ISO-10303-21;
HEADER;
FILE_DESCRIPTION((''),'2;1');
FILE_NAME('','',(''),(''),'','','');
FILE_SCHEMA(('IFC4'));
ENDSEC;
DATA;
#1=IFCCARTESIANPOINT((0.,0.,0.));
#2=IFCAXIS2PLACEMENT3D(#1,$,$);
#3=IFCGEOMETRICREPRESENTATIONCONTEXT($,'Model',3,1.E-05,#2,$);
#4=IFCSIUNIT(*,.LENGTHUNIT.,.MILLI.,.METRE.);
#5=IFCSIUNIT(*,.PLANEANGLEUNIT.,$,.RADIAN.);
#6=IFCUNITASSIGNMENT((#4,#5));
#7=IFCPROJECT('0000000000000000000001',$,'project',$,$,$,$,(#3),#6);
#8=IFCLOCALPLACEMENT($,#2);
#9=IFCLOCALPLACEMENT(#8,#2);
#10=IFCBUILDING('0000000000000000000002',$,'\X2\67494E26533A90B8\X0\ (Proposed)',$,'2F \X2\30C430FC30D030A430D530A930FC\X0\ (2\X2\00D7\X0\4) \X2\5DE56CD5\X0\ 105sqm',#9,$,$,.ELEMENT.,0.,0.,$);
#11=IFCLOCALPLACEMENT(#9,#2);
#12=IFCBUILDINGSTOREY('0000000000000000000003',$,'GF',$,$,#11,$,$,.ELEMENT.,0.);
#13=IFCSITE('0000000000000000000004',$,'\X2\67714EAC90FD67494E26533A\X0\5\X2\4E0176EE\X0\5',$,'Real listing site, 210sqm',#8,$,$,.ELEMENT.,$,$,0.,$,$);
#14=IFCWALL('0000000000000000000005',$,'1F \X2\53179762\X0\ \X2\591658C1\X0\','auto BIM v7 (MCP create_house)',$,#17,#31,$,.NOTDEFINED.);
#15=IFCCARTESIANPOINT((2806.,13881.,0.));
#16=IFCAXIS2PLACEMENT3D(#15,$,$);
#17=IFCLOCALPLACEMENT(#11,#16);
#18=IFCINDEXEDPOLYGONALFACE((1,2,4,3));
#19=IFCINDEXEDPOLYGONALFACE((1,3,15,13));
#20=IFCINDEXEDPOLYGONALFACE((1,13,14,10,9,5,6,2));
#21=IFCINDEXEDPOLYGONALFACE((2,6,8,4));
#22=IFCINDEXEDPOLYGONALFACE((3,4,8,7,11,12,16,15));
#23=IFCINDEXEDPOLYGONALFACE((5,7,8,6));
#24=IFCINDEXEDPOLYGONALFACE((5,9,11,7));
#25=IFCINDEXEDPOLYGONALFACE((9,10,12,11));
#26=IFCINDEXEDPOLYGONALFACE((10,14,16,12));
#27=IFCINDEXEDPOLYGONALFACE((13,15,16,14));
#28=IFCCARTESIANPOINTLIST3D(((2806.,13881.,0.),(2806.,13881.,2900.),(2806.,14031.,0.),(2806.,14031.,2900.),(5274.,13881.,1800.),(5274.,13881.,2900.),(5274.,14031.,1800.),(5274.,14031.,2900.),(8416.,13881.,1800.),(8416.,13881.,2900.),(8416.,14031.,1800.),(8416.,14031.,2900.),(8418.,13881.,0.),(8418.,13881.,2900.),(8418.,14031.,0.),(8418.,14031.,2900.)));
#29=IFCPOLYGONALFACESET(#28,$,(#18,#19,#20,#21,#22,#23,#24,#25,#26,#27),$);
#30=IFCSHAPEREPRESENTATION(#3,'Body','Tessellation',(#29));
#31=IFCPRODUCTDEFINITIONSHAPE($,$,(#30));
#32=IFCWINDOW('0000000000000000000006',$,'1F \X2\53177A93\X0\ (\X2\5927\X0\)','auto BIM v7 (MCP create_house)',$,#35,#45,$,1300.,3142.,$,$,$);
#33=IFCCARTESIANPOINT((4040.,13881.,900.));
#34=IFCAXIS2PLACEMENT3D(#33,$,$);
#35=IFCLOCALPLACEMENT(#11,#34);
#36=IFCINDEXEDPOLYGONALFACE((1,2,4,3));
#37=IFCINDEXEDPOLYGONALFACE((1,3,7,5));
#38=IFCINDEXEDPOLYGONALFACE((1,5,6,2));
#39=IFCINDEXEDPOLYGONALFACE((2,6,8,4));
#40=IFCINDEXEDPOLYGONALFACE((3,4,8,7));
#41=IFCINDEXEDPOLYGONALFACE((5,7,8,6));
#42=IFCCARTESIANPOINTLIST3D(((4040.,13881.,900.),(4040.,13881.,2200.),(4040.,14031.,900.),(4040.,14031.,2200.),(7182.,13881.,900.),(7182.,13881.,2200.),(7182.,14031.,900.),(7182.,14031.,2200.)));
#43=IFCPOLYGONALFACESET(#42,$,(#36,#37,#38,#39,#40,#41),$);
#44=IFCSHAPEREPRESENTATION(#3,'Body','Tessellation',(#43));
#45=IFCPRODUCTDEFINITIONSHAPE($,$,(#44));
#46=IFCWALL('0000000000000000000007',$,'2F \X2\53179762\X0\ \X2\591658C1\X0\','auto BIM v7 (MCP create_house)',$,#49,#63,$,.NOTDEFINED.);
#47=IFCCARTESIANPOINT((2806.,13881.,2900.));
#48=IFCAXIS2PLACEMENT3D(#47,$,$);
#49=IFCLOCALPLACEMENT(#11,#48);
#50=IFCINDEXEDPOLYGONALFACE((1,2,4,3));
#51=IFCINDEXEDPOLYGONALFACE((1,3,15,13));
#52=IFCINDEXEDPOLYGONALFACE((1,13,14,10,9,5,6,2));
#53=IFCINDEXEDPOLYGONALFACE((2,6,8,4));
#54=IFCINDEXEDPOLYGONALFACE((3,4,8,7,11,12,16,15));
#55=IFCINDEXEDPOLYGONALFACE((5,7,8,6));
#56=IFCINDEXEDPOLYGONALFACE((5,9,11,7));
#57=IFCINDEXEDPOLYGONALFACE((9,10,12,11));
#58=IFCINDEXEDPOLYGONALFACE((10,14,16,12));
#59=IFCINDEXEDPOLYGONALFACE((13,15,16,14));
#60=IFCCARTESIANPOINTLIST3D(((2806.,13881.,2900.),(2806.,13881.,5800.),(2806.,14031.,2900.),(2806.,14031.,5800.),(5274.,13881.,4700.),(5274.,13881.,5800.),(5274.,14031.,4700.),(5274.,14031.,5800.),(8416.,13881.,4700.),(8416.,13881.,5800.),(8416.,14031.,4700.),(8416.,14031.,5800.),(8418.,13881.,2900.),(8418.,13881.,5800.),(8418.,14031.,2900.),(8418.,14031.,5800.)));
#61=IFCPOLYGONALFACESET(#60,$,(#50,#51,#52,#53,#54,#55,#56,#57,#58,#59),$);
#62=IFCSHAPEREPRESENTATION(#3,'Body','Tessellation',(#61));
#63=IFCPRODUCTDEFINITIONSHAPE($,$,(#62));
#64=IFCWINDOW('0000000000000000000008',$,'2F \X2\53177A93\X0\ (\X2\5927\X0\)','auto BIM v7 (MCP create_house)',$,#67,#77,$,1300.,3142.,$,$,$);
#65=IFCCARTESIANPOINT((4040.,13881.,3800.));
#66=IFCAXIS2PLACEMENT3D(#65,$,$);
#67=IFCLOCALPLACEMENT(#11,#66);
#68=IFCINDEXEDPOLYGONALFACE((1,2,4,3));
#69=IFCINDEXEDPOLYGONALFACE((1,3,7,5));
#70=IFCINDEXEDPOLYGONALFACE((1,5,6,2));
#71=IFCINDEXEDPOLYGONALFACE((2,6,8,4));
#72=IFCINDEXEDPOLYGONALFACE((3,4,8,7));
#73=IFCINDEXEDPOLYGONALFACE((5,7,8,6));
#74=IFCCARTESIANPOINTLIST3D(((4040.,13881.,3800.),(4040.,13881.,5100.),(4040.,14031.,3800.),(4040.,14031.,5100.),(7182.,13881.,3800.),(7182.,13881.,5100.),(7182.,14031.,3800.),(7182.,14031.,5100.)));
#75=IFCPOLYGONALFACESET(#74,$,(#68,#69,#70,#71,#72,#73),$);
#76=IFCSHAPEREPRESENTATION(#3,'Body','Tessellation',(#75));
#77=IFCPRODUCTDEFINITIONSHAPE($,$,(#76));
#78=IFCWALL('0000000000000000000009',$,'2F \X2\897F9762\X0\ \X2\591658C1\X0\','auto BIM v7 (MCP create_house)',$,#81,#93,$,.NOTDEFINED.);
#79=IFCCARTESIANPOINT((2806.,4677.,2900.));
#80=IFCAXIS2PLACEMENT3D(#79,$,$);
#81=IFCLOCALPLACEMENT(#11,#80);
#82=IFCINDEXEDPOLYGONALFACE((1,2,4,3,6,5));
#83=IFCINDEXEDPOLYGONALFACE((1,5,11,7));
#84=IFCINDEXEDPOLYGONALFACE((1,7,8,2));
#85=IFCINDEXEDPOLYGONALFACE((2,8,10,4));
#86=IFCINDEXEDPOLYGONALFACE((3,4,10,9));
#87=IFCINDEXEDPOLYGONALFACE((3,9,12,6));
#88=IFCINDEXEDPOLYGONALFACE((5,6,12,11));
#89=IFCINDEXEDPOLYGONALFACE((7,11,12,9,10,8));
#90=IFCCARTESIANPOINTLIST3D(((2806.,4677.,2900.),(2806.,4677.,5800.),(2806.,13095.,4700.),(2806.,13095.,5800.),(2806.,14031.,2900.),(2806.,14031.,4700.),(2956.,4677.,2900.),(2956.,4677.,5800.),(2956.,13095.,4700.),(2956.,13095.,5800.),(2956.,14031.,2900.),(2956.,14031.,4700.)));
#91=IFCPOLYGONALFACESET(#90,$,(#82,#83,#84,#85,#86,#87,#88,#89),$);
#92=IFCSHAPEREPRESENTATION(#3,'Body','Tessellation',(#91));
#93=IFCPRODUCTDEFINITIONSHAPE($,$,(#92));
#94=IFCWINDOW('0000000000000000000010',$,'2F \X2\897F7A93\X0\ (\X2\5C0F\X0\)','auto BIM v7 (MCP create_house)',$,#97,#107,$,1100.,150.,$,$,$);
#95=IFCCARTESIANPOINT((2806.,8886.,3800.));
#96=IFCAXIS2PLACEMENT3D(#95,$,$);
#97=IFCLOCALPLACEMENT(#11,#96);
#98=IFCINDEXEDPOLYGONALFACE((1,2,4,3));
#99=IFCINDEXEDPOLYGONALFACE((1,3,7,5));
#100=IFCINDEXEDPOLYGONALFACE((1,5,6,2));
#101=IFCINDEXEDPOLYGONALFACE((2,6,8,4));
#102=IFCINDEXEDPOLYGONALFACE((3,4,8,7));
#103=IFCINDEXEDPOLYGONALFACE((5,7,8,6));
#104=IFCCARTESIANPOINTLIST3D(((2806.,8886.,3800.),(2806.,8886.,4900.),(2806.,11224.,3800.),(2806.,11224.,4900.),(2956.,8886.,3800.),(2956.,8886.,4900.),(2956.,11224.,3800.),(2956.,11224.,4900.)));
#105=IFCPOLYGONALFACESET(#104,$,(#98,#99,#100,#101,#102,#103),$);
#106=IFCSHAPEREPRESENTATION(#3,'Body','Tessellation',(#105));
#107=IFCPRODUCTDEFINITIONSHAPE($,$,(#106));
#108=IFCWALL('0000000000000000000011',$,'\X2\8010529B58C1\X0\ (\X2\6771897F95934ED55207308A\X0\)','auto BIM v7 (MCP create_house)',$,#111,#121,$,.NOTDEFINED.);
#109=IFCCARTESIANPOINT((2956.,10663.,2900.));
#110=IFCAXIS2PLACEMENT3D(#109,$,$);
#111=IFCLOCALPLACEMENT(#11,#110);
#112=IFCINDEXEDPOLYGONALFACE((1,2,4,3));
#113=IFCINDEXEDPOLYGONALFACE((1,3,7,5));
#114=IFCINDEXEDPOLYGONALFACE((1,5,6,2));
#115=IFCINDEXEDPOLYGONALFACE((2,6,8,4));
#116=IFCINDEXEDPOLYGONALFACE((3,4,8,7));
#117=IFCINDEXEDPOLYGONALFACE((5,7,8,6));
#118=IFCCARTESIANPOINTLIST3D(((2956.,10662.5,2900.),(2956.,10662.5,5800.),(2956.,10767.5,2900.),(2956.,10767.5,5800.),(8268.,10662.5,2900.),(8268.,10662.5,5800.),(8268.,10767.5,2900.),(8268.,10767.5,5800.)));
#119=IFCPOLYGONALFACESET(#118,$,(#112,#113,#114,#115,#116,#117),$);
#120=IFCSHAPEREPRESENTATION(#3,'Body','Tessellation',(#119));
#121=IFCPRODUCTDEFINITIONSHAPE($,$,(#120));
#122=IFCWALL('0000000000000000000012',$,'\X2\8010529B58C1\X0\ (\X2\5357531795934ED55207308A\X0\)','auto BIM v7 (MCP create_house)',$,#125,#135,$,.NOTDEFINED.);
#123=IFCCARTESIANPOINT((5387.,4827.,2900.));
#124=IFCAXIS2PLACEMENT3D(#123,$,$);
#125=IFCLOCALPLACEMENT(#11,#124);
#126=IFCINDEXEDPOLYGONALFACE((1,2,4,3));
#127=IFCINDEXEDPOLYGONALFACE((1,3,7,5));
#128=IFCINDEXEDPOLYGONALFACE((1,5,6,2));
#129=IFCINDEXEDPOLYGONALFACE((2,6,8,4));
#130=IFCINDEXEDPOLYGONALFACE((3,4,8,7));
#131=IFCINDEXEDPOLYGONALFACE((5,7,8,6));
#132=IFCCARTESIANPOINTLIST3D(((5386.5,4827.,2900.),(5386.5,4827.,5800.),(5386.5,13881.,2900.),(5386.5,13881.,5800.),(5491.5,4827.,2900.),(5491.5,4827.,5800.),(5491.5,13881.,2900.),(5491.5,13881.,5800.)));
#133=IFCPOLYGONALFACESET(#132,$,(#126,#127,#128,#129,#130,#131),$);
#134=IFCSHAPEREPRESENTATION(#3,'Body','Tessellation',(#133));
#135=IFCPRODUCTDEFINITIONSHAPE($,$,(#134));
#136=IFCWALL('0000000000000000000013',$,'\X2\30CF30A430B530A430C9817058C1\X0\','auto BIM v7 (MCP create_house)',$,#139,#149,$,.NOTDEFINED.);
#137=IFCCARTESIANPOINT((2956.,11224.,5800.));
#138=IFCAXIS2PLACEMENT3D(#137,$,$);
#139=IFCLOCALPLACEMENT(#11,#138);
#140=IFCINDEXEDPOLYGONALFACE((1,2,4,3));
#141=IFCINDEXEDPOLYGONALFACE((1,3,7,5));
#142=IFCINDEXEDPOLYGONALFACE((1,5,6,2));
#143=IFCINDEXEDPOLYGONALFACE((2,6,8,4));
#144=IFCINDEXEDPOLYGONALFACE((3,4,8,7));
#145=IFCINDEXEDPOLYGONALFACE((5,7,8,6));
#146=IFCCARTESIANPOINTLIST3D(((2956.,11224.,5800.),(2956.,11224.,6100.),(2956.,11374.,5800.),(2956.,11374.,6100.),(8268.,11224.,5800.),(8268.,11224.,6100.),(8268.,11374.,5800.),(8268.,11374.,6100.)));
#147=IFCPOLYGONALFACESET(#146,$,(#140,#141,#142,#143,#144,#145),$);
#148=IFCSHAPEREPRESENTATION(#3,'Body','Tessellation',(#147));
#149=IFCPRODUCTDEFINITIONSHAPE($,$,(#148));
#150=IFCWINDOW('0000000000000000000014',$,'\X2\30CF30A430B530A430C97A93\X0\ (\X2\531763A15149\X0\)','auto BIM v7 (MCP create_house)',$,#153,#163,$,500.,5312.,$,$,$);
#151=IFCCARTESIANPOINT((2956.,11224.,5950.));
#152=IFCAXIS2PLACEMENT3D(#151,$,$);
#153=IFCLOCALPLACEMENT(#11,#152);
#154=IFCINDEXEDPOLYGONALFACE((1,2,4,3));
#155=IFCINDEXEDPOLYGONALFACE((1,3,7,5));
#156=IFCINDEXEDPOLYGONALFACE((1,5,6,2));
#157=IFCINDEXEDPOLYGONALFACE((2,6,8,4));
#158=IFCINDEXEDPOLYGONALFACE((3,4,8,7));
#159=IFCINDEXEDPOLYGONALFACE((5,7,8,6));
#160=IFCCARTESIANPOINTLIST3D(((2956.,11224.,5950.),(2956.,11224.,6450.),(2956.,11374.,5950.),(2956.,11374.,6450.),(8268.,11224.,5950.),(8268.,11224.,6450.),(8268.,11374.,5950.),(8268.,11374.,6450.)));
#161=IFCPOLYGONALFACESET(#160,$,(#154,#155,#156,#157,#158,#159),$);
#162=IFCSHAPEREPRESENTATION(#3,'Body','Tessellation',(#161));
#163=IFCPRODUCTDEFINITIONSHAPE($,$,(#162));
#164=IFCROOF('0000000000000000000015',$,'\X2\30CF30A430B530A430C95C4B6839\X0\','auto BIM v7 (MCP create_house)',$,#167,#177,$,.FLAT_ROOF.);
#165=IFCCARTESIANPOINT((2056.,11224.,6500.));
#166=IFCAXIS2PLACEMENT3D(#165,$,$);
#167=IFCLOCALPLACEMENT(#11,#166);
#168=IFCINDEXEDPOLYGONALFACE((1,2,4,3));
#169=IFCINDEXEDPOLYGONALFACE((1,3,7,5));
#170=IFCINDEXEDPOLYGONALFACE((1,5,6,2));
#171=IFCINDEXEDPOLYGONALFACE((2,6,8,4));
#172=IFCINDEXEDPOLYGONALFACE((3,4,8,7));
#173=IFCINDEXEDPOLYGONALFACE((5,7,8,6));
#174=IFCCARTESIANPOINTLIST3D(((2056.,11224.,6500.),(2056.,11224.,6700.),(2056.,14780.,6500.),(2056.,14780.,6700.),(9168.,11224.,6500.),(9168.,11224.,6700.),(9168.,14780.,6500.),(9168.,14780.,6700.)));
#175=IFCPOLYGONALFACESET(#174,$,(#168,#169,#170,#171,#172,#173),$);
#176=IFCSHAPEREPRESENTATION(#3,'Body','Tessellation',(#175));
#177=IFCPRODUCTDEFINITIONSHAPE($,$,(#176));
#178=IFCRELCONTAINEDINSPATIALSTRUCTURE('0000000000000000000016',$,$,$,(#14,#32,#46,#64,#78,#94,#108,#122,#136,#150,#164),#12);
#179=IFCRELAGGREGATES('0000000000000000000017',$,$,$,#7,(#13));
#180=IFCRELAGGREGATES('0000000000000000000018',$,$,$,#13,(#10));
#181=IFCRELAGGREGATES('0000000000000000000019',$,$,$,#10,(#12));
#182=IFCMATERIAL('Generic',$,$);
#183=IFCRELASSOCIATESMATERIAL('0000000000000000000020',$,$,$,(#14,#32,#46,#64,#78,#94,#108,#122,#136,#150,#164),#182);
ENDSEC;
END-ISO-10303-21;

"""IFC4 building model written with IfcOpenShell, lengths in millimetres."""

from ifc_helpers import new_model, si_unit, frame, frame_2d, origin, place, context, project, spatial, rectangle, extrude, material, element, fill, save


model = new_model("IFC4")

# Units and contexts
model_context = context("Model", 3, precision=1e-05, world=origin())
ifc_project = project(units=[si_unit("LENGTHUNIT", "METRE", prefix="MILLI"), si_unit("PLANEANGLEUNIT", "RADIAN")], contexts=[model_context])

# Site, building, storey
site_placement = place(None, origin())
site = spatial("IfcSite", under=ifc_project, at=site_placement, Name="東京都杉並区5丁目5", ObjectType="Real listing site, 210sqm", CompositionType="ELEMENT", RefElevation=0.0)
building_placement = place(site_placement, origin())
building = spatial("IfcBuilding", under=site, at=building_placement, Name="杉並区邸 (Proposed)", ObjectType="2F ツーバイフォー (2×4) 工法 105sqm", CompositionType="ELEMENT", ElevationOfRefHeight=0.0, ElevationOfTerrain=0.0)
storey_placement = place(building_placement, origin())
storey = spatial("IfcBuildingStorey", under=building, at=storey_placement, Name="GF", CompositionType="ELEMENT", Elevation=0.0)

# Wall, opening, window
ifc_material = material(Name="Generic")
wall_1_placement = place(storey_placement, frame((2806.0, 13881.0, 0.0)))
wall_1 = element("IfcWall", 1, at=wall_1_placement, inside=storey, material=ifc_material, Name="1F 北面 外壁", Description="auto BIM v7 (MCP create_house)", PredefinedType="NOTDEFINED", context=model_context, shape_type="SweptSolid", body=[
    extrude(rectangle(XDim=5612.0, YDim=150.0, at=frame_2d((2806.0, 75.0))), frame((2806.0, 13881.0, 0.0)), (0.0, 0.0, 1.0), 2900.0),
])
opening_1_placement = place(storey_placement, frame((4040.0, 13881.0, 900.0)))
opening_1 = element("IfcOpeningElement", 2, at=opening_1_placement, cuts=wall_1, PredefinedType="NOTDEFINED", context=model_context, shape_type="SweptSolid", body=[
    extrude(rectangle(XDim=3142.0, YDim=150.0, at=frame_2d((1571.0, 75.0))), frame((4040.0, 13881.0, 900.0)), (0.0, 0.0, 1.0), 1300.0),
])
window_1_placement = place(storey_placement, frame((4040.0, 13881.0, 900.0)))
window_1 = element("IfcWindow", 3, at=window_1_placement, inside=storey, material=ifc_material, Name="1F 北窓 (大)", Description="auto BIM v7 (MCP create_house)", OverallHeight=1300.0, OverallWidth=3142.0, context=model_context, shape_type="SweptSolid", body=[
    extrude(rectangle(XDim=3142.0, YDim=150.0, at=frame_2d((1571.0, 75.0))), frame((4040.0, 13881.0, 900.0)), (0.0, 0.0, 1.0), 1300.0),
])
fill(opening_1, window_1)

# Walls, openings, windows
wall_2_placement = place(storey_placement, frame((2806.0, 13881.0, 2900.0)))
wall_2 = element("IfcWall", 4, at=wall_2_placement, inside=storey, material=ifc_material, Name="2F 北面 外壁", Description="auto BIM v7 (MCP create_house)", PredefinedType="NOTDEFINED", context=model_context, shape_type="SweptSolid", body=[
    extrude(rectangle(XDim=5612.0, YDim=150.0, at=frame_2d((2806.0, 75.0))), frame((2806.0, 13881.0, 2900.0)), (0.0, 0.0, 1.0), 2900.0),
])
opening_2_placement = place(storey_placement, frame((4040.0, 13881.0, 3800.0)))
opening_2 = element("IfcOpeningElement", 5, at=opening_2_placement, cuts=wall_2, PredefinedType="NOTDEFINED", context=model_context, shape_type="SweptSolid", body=[
    extrude(rectangle(XDim=3142.0, YDim=150.0, at=frame_2d((1571.0, 75.0))), frame((4040.0, 13881.0, 3800.0)), (0.0, 0.0, 1.0), 1300.0),
])
window_2_placement = place(storey_placement, frame((4040.0, 13881.0, 3800.0)))
window_2 = element("IfcWindow", 6, at=window_2_placement, inside=storey, material=ifc_material, Name="2F 北窓 (大)", Description="auto BIM v7 (MCP create_house)", OverallHeight=1300.0, OverallWidth=3142.0, context=model_context, shape_type="SweptSolid", body=[
    extrude(rectangle(XDim=3142.0, YDim=150.0, at=frame_2d((1571.0, 75.0))), frame((4040.0, 13881.0, 3800.0)), (0.0, 0.0, 1.0), 1300.0),
])
fill(opening_2, window_2)
wall_3_placement = place(storey_placement, frame((2806.0, 4677.0, 2900.0)))
wall_3 = element("IfcWall", 7, at=wall_3_placement, inside=storey, material=ifc_material, Name="2F 西面 外壁", Description="auto BIM v7 (MCP create_house)", PredefinedType="NOTDEFINED", context=model_context, shape_type="SweptSolid", body=[
    extrude(rectangle(XDim=150.0, YDim=9354.0, at=frame_2d((75.0, 4677.0))), frame((2806.0, 4677.0, 2900.0)), (0.0, 0.0, 1.0), 2900.0),
])
opening_3_placement = place(storey_placement, frame((2806.0, 8886.0, 3800.0)))
opening_3 = element("IfcOpeningElement", 8, at=opening_3_placement, cuts=wall_3, PredefinedType="NOTDEFINED", context=model_context, shape_type="SweptSolid", body=[
    extrude(rectangle(XDim=150.0, YDim=2338.0, at=frame_2d((75.0, 1169.0))), frame((2806.0, 8886.0, 3800.0)), (0.0, 0.0, 1.0), 1100.0),
])
window_3_placement = place(storey_placement, frame((2806.0, 8886.0, 3800.0)))
window_3 = element("IfcWindow", 9, at=window_3_placement, inside=storey, material=ifc_material, Name="2F 西窓 (小)", Description="auto BIM v7 (MCP create_house)", OverallHeight=1100.0, OverallWidth=150.0, context=model_context, shape_type="SweptSolid", body=[
    extrude(rectangle(XDim=150.0, YDim=2338.0, at=frame_2d((75.0, 1169.0))), frame((2806.0, 8886.0, 3800.0)), (0.0, 0.0, 1.0), 1100.0),
])
fill(opening_3, window_3)

# Walls
wall_4_placement = place(storey_placement, frame((2956.0, 10663.0, 2900.0)))
element("IfcWall", 10, at=wall_4_placement, inside=storey, material=ifc_material, Name="耐力壁 (東西間仕切り)", Description="auto BIM v7 (MCP create_house)", PredefinedType="NOTDEFINED", context=model_context, shape_type="SweptSolid", body=[
    extrude(rectangle(XDim=5312.0, YDim=105.0, at=frame_2d((2656.0, 52.0))), frame((2956.0, 10663.0, 2900.0)), (0.0, 0.0, 1.0), 2900.0),
])
wall_5_placement = place(storey_placement, frame((5387.0, 4827.0, 2900.0)))
element("IfcWall", 11, at=wall_5_placement, inside=storey, material=ifc_material, Name="耐力壁 (南北間仕切り)", Description="auto BIM v7 (MCP create_house)", PredefinedType="NOTDEFINED", context=model_context, shape_type="SweptSolid", body=[
    extrude(rectangle(XDim=105.0, YDim=9054.0, at=frame_2d((52.0, 4527.0))), frame((5387.0, 4827.0, 2900.0)), (0.0, 0.0, 1.0), 2900.0),
])

# Wall, opening, window
wall_6_placement = place(storey_placement, frame((2956.0, 11224.0, 5800.0)))
wall_6 = element("IfcWall", 12, at=wall_6_placement, inside=storey, material=ifc_material, Name="ハイサイド腰壁", Description="auto BIM v7 (MCP create_house)", PredefinedType="NOTDEFINED", context=model_context, shape_type="SweptSolid", body=[
    extrude(rectangle(XDim=5312.0, YDim=150.0, at=frame_2d((2656.0, 75.0))), frame((2956.0, 11224.0, 5800.0)), (0.0, 0.0, 1.0), 700.0),
])
opening_4_placement = place(storey_placement, frame((2956.0, 11224.0, 5950.0)))
opening_4 = element("IfcOpeningElement", 13, at=opening_4_placement, cuts=wall_6, PredefinedType="NOTDEFINED", context=model_context, shape_type="SweptSolid", body=[
    extrude(rectangle(XDim=5312.0, YDim=150.0, at=frame_2d((2656.0, 75.0))), frame((2956.0, 11224.0, 5950.0)), (0.0, 0.0, 1.0), 500.0),
])
window_4_placement = place(storey_placement, frame((2956.0, 11224.0, 5950.0)))
window_4 = element("IfcWindow", 14, at=window_4_placement, inside=storey, material=ifc_material, Name="ハイサイド窓 (北採光)", Description="auto BIM v7 (MCP create_house)", OverallHeight=500.0, OverallWidth=5312.0, context=model_context, shape_type="SweptSolid", body=[
    extrude(rectangle(XDim=5312.0, YDim=150.0, at=frame_2d((2656.0, 75.0))), frame((2956.0, 11224.0, 5950.0)), (0.0, 0.0, 1.0), 500.0),
])
fill(opening_4, window_4)

# Roof
roof_placement = place(storey_placement, frame((2056.0, 11224.0, 6500.0)))
element("IfcRoof", 15, at=roof_placement, inside=storey, material=ifc_material, Name="ハイサイド屋根", Description="auto BIM v7 (MCP create_house)", PredefinedType="FLAT_ROOF", context=model_context, shape_type="SweptSolid", body=[
    extrude(rectangle(XDim=7112.0, YDim=3556.0, at=frame_2d((3556.0, 1778.0))), frame((2056.0, 11224.0, 6500.0)), (0.0, 0.0, 1.0), 200.0),
])

save(model, "model.ifc")
